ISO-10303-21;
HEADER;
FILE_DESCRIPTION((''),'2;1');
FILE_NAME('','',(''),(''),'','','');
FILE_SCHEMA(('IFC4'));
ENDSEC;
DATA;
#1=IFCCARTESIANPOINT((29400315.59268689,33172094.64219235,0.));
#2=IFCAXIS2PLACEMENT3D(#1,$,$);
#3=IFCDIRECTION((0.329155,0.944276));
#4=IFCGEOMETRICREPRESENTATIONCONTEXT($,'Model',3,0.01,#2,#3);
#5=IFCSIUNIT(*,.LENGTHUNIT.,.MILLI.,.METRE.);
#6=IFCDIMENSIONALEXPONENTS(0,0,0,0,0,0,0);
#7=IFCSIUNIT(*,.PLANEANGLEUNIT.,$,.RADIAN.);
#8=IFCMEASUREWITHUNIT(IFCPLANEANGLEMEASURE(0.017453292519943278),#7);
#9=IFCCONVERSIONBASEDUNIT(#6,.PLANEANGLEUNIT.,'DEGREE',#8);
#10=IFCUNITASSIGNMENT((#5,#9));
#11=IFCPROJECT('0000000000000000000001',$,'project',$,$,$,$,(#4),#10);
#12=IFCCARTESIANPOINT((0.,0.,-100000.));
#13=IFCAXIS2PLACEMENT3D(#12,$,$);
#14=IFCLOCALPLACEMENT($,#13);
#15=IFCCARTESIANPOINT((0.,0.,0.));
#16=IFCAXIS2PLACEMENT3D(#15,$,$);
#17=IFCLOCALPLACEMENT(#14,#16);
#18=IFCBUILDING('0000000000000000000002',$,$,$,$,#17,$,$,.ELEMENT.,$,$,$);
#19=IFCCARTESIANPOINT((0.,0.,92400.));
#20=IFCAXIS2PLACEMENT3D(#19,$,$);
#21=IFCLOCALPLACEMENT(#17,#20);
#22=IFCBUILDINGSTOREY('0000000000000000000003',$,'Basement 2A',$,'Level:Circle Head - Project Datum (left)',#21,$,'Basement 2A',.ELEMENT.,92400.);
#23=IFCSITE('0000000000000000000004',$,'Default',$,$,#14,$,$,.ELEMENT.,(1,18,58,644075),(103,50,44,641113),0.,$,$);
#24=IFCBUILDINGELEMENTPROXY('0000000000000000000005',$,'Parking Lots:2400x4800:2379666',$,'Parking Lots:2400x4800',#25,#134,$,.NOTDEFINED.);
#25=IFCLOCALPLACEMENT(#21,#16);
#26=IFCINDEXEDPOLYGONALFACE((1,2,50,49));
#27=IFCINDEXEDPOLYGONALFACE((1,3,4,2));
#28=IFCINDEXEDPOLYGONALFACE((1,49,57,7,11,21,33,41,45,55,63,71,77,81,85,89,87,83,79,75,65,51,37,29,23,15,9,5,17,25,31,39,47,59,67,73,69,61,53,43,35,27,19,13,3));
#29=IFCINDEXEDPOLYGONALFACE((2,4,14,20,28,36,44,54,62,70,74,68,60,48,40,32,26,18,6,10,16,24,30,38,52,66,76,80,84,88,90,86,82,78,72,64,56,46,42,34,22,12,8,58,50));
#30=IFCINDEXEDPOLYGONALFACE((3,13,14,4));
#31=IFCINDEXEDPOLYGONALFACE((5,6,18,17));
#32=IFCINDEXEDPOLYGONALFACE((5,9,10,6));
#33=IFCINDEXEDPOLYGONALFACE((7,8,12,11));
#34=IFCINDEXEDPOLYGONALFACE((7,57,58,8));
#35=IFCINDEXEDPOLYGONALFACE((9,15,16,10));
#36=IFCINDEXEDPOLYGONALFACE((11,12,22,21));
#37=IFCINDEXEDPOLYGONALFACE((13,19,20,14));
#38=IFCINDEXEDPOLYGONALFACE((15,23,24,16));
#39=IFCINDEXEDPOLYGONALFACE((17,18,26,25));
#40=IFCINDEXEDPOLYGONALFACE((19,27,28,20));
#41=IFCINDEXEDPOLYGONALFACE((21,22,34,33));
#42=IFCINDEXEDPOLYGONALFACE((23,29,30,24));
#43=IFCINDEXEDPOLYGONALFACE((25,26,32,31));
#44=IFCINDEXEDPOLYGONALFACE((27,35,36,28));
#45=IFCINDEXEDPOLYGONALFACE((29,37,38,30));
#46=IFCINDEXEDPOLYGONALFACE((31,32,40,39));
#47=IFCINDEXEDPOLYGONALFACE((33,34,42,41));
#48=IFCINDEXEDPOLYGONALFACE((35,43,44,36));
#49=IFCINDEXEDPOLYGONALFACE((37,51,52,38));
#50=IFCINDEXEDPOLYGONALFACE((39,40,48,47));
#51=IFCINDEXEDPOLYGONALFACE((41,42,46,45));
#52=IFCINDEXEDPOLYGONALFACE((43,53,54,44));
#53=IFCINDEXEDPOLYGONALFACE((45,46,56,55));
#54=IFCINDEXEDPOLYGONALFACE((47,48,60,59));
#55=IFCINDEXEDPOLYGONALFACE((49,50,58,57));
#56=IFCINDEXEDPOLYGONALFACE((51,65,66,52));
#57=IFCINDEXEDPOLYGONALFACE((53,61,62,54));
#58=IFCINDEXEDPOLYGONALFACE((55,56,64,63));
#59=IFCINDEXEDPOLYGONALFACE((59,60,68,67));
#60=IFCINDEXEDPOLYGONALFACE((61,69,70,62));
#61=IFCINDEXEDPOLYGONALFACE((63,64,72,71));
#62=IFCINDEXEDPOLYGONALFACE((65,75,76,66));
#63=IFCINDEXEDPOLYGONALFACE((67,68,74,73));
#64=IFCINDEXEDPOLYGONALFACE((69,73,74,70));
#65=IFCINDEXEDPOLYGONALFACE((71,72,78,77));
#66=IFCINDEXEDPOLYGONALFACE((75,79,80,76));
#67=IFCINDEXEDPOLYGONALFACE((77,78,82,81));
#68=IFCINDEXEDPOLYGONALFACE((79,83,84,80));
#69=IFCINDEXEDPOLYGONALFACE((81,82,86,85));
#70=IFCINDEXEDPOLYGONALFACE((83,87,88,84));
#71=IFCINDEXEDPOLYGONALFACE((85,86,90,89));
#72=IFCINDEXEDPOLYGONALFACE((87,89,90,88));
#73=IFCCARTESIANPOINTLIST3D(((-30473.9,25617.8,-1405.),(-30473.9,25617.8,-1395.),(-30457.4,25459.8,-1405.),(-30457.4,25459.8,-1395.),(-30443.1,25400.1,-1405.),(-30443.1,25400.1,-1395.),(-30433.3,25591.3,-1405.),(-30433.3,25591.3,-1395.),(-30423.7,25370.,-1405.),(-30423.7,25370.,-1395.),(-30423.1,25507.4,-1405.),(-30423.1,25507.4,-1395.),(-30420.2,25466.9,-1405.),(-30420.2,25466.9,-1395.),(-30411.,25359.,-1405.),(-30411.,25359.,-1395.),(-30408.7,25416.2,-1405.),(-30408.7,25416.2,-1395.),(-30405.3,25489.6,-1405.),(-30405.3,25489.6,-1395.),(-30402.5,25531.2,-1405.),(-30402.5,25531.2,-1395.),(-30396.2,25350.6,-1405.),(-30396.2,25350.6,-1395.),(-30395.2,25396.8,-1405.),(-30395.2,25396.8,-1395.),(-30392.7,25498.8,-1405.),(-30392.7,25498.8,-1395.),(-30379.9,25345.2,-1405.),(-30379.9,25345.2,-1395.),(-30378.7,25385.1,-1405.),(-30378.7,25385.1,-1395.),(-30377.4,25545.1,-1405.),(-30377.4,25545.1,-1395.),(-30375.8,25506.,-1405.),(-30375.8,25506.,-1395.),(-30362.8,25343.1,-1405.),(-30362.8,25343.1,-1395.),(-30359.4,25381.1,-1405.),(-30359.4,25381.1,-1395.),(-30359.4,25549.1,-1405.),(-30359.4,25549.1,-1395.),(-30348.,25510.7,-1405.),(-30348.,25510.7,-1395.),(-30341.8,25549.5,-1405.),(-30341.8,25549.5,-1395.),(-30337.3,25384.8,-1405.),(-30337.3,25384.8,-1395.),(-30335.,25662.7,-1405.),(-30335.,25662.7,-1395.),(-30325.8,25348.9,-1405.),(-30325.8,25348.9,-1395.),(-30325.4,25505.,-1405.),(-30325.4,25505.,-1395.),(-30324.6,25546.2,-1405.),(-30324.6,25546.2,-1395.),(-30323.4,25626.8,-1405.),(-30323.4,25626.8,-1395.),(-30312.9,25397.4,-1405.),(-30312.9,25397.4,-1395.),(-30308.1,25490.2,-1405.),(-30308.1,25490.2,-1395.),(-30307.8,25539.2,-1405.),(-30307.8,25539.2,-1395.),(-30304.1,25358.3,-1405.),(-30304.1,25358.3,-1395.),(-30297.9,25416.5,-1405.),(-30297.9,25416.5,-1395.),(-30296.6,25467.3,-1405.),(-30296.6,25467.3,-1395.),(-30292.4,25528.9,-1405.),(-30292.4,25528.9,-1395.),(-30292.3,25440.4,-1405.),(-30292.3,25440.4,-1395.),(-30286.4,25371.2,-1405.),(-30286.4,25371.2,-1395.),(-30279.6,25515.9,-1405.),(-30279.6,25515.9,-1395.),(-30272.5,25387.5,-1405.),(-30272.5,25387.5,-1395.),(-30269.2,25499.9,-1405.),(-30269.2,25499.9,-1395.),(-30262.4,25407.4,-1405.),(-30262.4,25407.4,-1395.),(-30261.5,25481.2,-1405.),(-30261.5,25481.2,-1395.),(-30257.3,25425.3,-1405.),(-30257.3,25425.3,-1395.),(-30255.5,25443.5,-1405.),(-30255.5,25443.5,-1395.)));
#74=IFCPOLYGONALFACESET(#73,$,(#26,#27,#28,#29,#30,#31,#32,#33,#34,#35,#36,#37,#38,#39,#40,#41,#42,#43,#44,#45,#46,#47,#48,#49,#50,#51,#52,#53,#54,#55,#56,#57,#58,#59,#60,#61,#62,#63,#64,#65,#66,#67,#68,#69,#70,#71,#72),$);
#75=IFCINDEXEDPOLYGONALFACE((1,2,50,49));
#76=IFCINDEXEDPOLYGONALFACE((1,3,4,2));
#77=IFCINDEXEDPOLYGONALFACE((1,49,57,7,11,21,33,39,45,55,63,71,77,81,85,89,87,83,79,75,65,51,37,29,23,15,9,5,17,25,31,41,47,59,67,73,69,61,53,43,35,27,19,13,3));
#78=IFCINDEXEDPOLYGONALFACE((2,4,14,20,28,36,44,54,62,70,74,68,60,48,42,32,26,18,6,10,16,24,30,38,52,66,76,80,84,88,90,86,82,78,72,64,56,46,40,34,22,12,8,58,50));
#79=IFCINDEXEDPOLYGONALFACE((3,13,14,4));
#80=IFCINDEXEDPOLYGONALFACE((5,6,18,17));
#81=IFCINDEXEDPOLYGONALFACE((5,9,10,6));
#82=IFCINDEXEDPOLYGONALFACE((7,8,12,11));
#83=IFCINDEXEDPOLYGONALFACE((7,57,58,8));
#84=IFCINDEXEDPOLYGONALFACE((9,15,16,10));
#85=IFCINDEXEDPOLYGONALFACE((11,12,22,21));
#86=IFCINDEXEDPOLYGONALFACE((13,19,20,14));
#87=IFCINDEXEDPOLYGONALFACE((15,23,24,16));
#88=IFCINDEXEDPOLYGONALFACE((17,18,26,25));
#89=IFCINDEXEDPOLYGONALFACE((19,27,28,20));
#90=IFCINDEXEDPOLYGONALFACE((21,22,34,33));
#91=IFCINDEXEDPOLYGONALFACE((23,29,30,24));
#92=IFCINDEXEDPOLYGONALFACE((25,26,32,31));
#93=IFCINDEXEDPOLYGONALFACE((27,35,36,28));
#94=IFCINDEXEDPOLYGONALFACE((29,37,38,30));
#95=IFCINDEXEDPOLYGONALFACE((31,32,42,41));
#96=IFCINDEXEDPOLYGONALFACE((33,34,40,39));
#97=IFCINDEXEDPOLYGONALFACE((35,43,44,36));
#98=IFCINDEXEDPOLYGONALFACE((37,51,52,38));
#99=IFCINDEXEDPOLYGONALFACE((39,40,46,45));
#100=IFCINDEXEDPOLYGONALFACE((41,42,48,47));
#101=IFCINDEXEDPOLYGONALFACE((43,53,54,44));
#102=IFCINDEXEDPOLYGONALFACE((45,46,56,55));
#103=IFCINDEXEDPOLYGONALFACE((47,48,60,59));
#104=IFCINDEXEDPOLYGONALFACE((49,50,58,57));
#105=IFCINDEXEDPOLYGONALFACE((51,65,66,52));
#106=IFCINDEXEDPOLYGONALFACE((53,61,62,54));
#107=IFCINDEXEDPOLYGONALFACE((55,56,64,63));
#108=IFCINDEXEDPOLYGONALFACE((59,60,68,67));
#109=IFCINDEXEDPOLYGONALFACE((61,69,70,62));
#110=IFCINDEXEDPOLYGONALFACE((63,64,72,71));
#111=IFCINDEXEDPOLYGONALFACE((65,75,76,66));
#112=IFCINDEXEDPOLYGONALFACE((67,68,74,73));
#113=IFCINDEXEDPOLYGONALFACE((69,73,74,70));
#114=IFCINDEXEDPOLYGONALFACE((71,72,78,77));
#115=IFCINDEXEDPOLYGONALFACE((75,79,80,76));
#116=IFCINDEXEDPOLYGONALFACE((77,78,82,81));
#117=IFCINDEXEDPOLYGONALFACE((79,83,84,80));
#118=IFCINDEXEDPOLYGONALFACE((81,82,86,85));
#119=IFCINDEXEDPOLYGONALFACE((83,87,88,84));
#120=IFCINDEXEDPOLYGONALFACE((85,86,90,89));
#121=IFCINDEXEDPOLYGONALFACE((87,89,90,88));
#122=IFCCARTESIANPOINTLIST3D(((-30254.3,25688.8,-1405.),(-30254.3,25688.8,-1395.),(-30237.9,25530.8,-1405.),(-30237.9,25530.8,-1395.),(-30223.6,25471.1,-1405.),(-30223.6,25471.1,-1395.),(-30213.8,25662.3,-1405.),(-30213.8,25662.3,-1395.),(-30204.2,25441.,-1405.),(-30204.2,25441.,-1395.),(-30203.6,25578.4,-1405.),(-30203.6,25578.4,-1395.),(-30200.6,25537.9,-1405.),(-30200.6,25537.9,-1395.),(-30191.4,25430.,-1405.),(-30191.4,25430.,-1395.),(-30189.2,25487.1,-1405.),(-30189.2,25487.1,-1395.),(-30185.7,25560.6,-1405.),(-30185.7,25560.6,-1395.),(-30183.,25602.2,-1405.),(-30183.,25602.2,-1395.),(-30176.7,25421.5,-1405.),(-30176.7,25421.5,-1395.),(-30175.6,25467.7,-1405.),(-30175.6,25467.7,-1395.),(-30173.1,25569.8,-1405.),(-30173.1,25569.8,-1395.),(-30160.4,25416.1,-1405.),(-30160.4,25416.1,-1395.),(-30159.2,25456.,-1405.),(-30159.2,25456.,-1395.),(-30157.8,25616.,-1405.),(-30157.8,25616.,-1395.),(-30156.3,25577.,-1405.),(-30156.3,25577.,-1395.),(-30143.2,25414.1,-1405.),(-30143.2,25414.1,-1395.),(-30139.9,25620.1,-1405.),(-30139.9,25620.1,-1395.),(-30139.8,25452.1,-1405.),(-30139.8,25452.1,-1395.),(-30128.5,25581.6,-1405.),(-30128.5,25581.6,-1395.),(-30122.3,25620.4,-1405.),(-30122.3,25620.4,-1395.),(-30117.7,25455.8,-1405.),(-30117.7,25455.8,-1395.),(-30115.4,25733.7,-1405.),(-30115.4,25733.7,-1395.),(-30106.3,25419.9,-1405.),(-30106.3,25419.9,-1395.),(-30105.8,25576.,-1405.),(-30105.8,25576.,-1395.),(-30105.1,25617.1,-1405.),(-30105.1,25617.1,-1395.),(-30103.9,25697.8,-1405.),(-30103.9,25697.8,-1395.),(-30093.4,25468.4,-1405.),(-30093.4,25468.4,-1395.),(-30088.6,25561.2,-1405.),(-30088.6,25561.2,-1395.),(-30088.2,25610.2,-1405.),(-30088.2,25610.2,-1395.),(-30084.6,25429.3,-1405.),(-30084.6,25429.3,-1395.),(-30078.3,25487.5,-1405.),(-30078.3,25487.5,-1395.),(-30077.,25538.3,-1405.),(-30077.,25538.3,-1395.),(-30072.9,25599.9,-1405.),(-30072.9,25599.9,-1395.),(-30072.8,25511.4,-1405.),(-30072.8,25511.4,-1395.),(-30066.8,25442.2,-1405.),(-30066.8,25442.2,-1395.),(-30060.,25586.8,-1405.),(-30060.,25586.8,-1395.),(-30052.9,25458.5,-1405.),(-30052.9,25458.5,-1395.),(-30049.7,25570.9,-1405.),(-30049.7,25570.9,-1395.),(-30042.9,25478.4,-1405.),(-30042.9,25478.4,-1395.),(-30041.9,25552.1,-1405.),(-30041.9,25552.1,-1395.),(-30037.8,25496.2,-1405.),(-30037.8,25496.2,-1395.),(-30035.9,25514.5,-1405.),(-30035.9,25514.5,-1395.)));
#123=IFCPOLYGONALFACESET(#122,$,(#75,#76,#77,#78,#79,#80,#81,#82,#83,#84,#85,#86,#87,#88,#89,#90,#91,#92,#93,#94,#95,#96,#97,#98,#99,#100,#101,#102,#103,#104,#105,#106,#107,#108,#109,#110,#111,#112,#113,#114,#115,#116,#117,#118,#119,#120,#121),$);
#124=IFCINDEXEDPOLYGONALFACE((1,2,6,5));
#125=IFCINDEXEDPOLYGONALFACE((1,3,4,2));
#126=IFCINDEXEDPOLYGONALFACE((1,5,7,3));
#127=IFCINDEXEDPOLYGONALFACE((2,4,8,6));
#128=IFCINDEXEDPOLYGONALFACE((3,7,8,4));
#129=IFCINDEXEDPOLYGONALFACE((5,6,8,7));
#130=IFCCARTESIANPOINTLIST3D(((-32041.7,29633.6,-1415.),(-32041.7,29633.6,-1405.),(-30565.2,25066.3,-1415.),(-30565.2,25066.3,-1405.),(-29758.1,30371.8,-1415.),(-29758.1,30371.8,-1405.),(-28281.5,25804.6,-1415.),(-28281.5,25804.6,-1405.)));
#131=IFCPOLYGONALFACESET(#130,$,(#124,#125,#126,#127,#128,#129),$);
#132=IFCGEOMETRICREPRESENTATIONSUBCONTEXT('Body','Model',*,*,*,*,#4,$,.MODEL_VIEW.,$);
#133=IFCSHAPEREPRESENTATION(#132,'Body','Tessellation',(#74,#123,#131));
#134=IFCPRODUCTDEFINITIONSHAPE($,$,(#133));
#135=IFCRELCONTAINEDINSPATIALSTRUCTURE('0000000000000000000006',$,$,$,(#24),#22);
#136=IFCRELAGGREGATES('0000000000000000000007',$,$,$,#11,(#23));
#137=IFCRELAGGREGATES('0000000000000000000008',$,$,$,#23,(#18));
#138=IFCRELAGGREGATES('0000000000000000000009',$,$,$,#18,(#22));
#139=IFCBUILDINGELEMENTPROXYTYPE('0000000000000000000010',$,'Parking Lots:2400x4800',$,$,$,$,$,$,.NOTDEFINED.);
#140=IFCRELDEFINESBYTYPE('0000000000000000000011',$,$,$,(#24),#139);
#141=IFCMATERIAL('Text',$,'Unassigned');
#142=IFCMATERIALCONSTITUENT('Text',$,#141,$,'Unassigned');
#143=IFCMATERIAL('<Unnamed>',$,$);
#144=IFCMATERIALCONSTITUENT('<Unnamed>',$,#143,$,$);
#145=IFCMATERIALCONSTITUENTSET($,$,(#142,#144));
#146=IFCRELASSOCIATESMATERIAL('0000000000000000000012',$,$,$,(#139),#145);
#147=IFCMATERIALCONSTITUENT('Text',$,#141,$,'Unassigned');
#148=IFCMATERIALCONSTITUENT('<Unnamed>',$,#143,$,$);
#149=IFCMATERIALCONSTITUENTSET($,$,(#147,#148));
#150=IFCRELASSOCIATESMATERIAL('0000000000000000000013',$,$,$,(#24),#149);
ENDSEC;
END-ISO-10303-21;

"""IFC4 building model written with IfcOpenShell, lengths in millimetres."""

from ifc_helpers import new_model, entity, si_unit, converted_unit, direction, frame, origin, place, context, subcontext, project, spatial, indexed_curve, outline, extrude, source, transform, mapped, material, constituent, constituent_set, type_object, type_shapes, element, save


model = new_model("IFC4")

# Units and contexts
model_context = context("Model", 3, precision=0.01, world=frame((29400315.59268689, 33172094.64219235, 0.0)), true_north=direction((0.329155, 0.944276)))
body_context = subcontext(model_context, "Body", "Model", "MODEL_VIEW")
ifc_project = project(units=[si_unit("LENGTHUNIT", "METRE", prefix="MILLI"), converted_unit("PLANEANGLEUNIT", "DEGREE", entity("IfcPlaneAngleMeasure", 0.017453292519943278), si_unit("PLANEANGLEUNIT", "RADIAN"), dimensions=[0, 0, 0, 0, 0, 0, 0])], contexts=[model_context])

# Site, building, storey
site_placement = place(None, frame((0.0, 0.0, -100000.0)))
site = spatial("IfcSite", under=ifc_project, at=site_placement, Name="Default", CompositionType="ELEMENT", RefLatitude=(1, 18, 58, 644075), RefLongitude=(103, 50, 44, 641113), RefElevation=0.0)
building_placement = place(site_placement, origin())
building = spatial("IfcBuilding", under=site, at=building_placement, CompositionType="ELEMENT")
storey_placement = place(building_placement, frame((0.0, 0.0, 92400.0)))
storey = spatial("IfcBuildingStorey", under=building, at=storey_placement, Name="Basement 2A", ObjectType="Level:Circle Head - Project Datum (left)", LongName="Basement 2A", CompositionType="ELEMENT", Elevation=92400.0)

# Building element proxy
ifc_material_1 = material(Name="Text", Category="Unassigned")
ifc_material_2 = material(Name="<Unnamed>")
ifc_constituent_1 = constituent(ifc_material_1, Name="Text", Category="Unassigned")
ifc_constituent_2 = constituent(ifc_material_2, Name="<Unnamed>")
ifc_constituent_set_1 = constituent_set(constituents=[ifc_constituent_1, ifc_constituent_2])
ifc_constituent_3 = constituent(ifc_material_1, Name="Text", Category="Unassigned")
ifc_constituent_4 = constituent(ifc_material_2, Name="<Unnamed>")
ifc_constituent_set_2 = constituent_set(constituents=[ifc_constituent_3, ifc_constituent_4])
building_element_proxy_type_1 = type_object("IfcBuildingElementProxyType", Name="Parking Lots:2400x4800", PredefinedType="NOTDEFINED", material=ifc_constituent_set_2)
shared_shape_1 = source(origin(), body_context, "Body", "SweptSolid", [
    extrude(outline(indexed_curve([(1.4, -113.1), (37.2, -113.1), (53.4, -108.4), (68.5, -100.5), (81.8, -89.8), (92.9, -76.5), (108.0, -42.2), (111.8, -18.9), (110.6, 3.0), (104.4, 23.5), (93.2, 42.7), (80.9, 56.7), (66.6, 68.1), (31.7, 83.5), (11.7, 87.1), (-7.3, 87.1), (-25.2, 83.4), (-42.2, 76.0), (-57.1, 65.7), (-69.2, 53.0), (-78.5, 38.0), (-84.8, 20.7), (-86.8, -7.9), (-77.9, -38.1), (-154.0, -1.2), (-124.3, 110.4), (-160.7, 120.1), (-198.2, -21.0), (-56.5, -92.8), (-42.3, -57.6), (-53.3, -32.8), (-54.2, -17.2), (-51.1, 0.9), (-40.0, 26.8), (-23.0, 42.8), (-1.2, 49.2), (24.3, 46.5), (49.2, 35.5), (66.3, 17.9), (74.2, -5.1), (71.6, -32.4), (62.8, -53.0), (48.9, -67.1), (30.2, -74.6), (6.6, -75.5), (1.4, -113.1)], self_intersect=False)), frame((327.7, -4489.5, 10.0), z_axis=(0.0, 0.0, 1.0), x_axis=(0.256974, -0.966418, 0.0)), (0.0, 0.0, 1.0), 10.0),
    extrude(outline(indexed_curve([(1.4, -113.1), (37.2, -113.1), (53.4, -108.4), (68.5, -100.5), (81.8, -89.8), (92.9, -76.5), (108.0, -42.2), (111.8, -18.9), (110.6, 3.0), (104.4, 23.5), (93.2, 42.7), (80.9, 56.7), (66.6, 68.1), (31.7, 83.5), (11.7, 87.1), (-7.3, 87.1), (-25.2, 83.4), (-42.2, 76.0), (-57.1, 65.7), (-69.2, 53.0), (-78.5, 38.0), (-84.8, 20.7), (-86.8, -7.9), (-77.9, -38.1), (-154.0, -1.2), (-124.3, 110.4), (-160.7, 120.1), (-198.2, -21.0), (-56.5, -92.8), (-42.3, -57.6), (-53.3, -32.8), (-54.2, -17.2), (-51.1, 0.9), (-40.0, 26.8), (-23.0, 42.8), (-1.2, 49.2), (24.3, 46.5), (49.2, 35.5), (66.3, 17.9), (74.2, -5.1), (71.6, -32.4), (62.8, -53.0), (48.9, -67.1), (30.2, -74.6), (6.6, -75.5), (1.4, -113.1)], self_intersect=False)), frame((558.5, -4489.5, 10.0), z_axis=(0.0, 0.0, 1.0), x_axis=(0.256974, -0.966418, 0.0)), (0.0, 0.0, 1.0), 10.0),
    extrude(outline(indexed_curve([(-1200.0, -2400.0), (1200.0, -2400.0), (1200.0, 2400.0), (-1200.0, 2400.0), (-1200.0, -2400.0)], self_intersect=False)), frame((1200.0, -2400.0, 0.0), z_axis=(0.0, 0.0, 1.0), x_axis=(-1.0, 0.0, 0.0)), (0.0, 0.0, 1.0), 10.0),
])
type_shapes(building_element_proxy_type_1, [shared_shape_1])
proxy_1_placement = place(storey_placement, frame((-32041.7, 29633.6, -1415.0), z_axis=(0.0, 0.0, 1.0), x_axis=(0.951511, 0.307614, 0.0)))
element("IfcBuildingElementProxy", 1, at=proxy_1_placement, inside=storey, type_object=building_element_proxy_type_1, material=ifc_constituent_set_1, Name="Parking Lots:2400x4800:2379666", ObjectType="Parking Lots:2400x4800", PredefinedType="NOTDEFINED", context=body_context, shape_type="MappedRepresentation", body=[
    mapped(shared_shape_1, transform((0.0, 0.0, 0.0), scale=1.0)),
])

save(model, "model.ifc")
